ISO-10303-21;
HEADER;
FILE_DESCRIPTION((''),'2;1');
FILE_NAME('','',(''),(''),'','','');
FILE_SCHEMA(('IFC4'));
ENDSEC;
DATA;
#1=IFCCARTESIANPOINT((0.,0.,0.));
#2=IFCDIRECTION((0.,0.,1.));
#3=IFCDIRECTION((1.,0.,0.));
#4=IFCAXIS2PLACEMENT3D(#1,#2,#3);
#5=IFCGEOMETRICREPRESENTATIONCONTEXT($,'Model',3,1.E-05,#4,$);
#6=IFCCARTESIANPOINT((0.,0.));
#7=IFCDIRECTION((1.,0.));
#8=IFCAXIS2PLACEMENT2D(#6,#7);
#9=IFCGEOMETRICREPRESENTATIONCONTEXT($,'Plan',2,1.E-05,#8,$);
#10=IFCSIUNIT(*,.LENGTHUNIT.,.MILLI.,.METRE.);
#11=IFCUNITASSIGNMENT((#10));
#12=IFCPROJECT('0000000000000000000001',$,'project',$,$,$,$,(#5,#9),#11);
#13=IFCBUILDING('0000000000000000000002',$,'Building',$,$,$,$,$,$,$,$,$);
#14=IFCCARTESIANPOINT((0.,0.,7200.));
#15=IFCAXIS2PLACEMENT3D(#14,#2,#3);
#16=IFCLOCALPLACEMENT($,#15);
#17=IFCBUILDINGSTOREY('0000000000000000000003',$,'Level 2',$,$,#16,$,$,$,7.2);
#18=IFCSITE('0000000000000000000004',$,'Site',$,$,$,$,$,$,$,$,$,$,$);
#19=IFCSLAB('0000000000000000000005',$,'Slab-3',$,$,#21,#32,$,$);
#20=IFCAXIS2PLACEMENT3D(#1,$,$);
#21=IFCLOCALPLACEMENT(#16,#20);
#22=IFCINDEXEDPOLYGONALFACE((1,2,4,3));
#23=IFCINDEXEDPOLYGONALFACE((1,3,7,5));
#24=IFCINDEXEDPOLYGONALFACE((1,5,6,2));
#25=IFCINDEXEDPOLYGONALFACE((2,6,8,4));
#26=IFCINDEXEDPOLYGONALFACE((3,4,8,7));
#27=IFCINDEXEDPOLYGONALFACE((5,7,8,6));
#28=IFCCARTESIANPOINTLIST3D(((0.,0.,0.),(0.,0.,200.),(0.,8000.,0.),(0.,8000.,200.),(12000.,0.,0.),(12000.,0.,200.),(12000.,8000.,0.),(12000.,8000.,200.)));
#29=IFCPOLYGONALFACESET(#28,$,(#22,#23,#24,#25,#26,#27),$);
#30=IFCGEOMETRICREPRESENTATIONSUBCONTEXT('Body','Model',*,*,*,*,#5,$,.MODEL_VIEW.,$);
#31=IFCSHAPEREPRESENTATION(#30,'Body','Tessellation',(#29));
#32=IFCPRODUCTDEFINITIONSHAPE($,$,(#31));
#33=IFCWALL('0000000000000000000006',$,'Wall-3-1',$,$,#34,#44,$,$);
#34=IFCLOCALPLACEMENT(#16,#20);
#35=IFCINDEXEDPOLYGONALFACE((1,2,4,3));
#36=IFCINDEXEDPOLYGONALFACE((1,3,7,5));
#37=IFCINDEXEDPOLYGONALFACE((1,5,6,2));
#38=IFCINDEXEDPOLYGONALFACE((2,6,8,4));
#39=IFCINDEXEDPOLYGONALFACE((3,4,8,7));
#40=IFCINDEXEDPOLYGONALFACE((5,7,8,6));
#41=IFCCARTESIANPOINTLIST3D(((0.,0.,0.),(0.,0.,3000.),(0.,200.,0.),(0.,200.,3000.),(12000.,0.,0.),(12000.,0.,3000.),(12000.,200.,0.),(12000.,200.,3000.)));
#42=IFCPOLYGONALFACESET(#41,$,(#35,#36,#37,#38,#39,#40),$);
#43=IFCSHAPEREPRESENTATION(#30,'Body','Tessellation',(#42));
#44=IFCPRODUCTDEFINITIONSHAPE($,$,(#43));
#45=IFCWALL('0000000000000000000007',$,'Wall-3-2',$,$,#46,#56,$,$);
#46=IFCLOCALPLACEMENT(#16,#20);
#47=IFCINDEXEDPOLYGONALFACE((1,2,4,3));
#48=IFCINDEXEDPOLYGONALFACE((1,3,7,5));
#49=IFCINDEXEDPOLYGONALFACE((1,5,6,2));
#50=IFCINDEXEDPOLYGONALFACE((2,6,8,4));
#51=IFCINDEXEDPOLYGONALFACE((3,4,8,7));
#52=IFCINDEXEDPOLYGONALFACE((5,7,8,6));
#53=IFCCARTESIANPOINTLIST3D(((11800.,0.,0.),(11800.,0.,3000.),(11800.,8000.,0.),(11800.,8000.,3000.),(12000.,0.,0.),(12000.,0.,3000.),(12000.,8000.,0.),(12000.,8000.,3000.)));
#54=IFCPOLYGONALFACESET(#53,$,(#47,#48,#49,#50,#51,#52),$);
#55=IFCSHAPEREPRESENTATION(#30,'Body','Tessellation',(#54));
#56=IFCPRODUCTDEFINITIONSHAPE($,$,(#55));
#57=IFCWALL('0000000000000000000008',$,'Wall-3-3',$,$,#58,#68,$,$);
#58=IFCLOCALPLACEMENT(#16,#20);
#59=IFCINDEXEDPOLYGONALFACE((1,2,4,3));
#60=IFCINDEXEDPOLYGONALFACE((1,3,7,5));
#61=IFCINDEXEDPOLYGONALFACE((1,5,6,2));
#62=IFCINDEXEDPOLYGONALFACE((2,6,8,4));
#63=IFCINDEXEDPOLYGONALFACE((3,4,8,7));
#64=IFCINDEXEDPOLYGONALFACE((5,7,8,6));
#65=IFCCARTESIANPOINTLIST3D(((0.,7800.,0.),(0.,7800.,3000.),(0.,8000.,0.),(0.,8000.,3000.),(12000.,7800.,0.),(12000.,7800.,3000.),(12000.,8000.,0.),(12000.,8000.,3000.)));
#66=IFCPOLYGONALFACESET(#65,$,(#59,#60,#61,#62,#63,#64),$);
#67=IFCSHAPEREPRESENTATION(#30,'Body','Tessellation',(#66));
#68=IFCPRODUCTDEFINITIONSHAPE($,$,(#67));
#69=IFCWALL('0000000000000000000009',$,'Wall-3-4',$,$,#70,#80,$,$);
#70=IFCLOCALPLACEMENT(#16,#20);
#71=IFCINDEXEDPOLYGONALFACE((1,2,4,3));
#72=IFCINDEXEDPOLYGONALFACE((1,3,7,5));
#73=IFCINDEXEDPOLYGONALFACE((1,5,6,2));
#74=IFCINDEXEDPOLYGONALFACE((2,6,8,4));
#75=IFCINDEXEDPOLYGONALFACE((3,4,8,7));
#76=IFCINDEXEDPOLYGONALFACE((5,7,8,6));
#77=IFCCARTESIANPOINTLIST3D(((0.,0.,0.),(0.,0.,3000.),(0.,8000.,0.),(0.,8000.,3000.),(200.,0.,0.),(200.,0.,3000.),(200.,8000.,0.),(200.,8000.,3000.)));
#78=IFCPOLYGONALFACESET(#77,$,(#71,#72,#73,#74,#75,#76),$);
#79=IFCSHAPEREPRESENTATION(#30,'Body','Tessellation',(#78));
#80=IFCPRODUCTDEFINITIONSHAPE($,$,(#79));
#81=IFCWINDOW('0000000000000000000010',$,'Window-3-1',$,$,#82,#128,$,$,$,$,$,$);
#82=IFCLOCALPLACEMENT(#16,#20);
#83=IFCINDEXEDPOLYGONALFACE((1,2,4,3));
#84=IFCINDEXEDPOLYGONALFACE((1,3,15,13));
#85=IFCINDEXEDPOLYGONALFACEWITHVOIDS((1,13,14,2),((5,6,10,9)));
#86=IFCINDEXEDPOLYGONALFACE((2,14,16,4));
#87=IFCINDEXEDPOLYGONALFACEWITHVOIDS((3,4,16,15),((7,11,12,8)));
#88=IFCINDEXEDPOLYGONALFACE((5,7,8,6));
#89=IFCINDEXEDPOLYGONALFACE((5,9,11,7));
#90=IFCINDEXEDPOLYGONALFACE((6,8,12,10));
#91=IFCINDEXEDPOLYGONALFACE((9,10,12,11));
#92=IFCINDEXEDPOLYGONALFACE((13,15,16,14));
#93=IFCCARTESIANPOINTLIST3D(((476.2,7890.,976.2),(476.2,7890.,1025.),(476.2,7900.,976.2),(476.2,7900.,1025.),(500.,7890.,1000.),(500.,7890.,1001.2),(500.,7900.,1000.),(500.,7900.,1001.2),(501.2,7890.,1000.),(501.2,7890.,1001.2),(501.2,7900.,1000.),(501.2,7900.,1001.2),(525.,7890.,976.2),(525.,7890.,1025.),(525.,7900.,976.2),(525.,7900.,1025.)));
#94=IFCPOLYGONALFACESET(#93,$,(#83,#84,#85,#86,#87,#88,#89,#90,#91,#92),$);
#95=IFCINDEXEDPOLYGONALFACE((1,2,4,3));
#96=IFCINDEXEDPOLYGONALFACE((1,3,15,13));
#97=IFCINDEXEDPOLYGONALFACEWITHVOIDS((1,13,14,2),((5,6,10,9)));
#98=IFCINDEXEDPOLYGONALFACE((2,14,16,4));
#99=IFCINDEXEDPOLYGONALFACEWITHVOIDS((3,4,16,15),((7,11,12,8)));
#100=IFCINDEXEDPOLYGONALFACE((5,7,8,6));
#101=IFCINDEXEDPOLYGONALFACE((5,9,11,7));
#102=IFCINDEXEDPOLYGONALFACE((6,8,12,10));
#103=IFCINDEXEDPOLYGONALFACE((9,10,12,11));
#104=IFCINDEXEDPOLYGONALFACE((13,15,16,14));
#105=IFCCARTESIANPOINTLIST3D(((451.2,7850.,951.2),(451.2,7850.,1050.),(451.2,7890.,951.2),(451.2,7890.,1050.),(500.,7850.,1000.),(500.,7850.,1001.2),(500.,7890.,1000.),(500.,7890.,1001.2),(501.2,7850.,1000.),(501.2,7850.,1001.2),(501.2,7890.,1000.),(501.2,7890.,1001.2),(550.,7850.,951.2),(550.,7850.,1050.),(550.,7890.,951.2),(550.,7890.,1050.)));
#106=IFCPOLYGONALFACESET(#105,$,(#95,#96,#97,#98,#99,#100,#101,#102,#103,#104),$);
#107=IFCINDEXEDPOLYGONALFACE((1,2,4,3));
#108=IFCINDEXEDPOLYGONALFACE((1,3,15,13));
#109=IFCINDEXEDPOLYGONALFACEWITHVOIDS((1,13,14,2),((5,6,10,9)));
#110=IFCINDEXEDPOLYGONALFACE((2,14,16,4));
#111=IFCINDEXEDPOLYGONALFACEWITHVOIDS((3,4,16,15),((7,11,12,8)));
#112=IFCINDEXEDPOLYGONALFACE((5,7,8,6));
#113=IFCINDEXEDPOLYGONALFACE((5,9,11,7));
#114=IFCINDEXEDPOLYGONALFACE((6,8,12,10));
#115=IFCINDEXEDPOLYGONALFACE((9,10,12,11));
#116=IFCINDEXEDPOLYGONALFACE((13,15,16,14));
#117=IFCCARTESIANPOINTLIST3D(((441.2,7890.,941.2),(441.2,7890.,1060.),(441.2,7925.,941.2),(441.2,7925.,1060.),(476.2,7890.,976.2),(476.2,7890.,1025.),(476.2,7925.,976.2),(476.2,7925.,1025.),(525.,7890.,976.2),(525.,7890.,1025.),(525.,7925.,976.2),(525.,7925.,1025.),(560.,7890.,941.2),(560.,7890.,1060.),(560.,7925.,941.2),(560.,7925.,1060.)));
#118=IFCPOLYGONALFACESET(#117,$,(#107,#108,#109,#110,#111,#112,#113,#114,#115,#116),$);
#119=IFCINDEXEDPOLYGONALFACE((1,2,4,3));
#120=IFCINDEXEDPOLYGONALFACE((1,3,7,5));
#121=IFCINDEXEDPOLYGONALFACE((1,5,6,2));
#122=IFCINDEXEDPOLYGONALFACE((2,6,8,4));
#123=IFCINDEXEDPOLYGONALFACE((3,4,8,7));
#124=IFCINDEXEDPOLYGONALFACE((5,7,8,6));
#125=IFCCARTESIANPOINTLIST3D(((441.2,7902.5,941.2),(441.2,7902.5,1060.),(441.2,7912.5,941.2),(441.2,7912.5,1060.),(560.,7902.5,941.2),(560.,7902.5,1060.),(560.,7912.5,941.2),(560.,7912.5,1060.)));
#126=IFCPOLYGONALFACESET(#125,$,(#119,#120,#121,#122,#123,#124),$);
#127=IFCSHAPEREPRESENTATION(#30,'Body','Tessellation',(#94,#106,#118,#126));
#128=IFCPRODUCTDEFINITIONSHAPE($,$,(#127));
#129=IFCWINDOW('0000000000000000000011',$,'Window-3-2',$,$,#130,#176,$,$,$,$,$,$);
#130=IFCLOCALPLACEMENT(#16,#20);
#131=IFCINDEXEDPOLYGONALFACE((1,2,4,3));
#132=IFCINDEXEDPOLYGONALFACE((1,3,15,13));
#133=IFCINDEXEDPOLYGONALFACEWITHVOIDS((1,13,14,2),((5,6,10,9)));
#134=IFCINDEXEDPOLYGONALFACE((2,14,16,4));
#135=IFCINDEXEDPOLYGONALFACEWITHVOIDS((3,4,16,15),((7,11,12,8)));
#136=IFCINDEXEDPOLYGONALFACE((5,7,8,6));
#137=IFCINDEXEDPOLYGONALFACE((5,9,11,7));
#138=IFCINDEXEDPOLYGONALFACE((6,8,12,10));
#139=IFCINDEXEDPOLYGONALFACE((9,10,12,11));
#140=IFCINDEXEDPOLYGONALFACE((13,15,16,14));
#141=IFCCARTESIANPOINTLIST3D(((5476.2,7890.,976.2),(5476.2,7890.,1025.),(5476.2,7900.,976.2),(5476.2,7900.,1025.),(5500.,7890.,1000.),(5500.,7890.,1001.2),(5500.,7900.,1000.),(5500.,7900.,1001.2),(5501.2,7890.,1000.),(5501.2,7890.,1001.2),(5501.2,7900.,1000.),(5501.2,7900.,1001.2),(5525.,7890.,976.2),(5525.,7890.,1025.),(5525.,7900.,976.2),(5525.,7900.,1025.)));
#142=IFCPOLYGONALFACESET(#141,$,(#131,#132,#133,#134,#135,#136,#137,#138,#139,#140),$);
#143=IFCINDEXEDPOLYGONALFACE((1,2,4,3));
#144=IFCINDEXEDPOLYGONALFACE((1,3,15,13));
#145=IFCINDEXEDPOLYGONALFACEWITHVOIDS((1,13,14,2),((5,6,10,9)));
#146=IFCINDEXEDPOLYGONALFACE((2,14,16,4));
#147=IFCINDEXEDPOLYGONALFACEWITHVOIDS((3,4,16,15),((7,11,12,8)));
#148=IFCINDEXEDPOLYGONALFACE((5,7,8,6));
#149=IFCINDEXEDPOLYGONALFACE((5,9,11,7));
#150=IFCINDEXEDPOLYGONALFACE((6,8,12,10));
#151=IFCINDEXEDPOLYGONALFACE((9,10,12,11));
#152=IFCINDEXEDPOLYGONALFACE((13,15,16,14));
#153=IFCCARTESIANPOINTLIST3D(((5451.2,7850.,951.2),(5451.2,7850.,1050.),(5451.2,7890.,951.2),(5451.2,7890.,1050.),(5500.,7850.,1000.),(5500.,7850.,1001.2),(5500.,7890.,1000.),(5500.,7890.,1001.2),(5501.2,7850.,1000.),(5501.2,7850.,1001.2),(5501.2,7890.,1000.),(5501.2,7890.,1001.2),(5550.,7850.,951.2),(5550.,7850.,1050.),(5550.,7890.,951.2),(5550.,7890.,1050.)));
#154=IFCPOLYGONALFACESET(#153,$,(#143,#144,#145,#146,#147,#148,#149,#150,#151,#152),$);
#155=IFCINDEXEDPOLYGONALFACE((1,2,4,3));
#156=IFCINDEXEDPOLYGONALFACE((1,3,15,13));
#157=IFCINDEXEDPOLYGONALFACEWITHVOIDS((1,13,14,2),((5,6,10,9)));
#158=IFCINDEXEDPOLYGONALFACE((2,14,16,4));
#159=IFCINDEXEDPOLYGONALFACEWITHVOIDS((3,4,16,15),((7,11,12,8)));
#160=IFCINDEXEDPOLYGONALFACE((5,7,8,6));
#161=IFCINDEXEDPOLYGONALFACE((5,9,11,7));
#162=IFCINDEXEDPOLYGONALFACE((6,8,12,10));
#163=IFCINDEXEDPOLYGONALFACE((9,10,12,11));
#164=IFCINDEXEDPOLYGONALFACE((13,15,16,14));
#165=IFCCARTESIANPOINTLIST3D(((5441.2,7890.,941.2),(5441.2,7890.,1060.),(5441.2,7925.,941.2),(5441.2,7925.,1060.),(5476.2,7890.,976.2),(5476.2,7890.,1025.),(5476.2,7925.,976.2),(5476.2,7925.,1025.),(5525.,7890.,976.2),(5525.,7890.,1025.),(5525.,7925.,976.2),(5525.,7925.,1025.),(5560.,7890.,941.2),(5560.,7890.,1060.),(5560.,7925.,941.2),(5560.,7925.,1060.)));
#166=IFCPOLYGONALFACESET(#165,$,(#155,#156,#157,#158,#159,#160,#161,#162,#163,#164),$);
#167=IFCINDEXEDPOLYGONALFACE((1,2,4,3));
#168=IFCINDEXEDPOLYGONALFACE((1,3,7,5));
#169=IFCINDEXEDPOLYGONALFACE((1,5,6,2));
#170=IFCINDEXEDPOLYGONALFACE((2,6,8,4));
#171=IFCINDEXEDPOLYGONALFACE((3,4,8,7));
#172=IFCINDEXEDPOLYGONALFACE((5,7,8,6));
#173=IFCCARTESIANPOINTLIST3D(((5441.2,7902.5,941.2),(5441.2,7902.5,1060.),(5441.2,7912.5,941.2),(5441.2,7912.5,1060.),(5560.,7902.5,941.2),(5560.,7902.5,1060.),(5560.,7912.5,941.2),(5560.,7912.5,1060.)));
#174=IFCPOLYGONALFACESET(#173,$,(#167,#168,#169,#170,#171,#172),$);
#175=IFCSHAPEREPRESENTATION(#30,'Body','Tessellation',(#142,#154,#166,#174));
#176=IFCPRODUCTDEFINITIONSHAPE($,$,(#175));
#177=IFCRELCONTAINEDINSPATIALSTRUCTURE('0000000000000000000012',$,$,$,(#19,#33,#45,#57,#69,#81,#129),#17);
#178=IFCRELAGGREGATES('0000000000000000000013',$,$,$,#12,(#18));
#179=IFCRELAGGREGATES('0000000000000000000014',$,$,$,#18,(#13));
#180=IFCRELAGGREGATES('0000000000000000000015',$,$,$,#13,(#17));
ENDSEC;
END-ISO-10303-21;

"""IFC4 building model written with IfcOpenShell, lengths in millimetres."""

from ifc_helpers import new_model, si_unit, frame, origin_with_axes, origin_2d_with_axis, place, context, subcontext, project, spatial, line, indexed_curve, outline, extrude, element, save


model = new_model("IFC4")

# Units and contexts
model_context = context("Model", 3, precision=1e-05, world=origin_with_axes())
plan_context = context("Plan", 2, precision=1e-05, world=origin_2d_with_axis())
body_context = subcontext(model_context, "Body", "Model", "MODEL_VIEW")
ifc_project = project(units=[si_unit("LENGTHUNIT", "METRE", prefix="MILLI")], contexts=[model_context, plan_context])

# Site, building, storey
site = spatial("IfcSite", under=ifc_project, Name="Site")
building = spatial("IfcBuilding", under=site, Name="Building")
storey_placement = place(None, frame((0.0, 0.0, 7200.0), z_axis=(0.0, 0.0, 1.0), x_axis=(1.0, 0.0, 0.0)))
storey = spatial("IfcBuildingStorey", under=building, at=storey_placement, Name="Level 2", Elevation=7.2)

# Slab
slab_placement = place(storey_placement, origin_with_axes())
element("IfcSlab", 1, at=slab_placement, inside=storey, Name="Slab-3", context=body_context, shape_type="SweptSolid", body=[
    extrude(outline(indexed_curve([(0.0, 0.0), (12000.0, 0.0), (12000.0, 8000.0), (0.0, 8000.0), (0.0, 0.0)])), None, (0.0, 0.0, 1.0), 200.0),
])

# Walls
wall_1_placement = place(storey_placement, origin_with_axes())
element("IfcWall", 2, at=wall_1_placement, inside=storey, Name="Wall-3-1", context=body_context, shape_type="SweptSolid", body=[
    extrude(outline(indexed_curve([(0.0, 0.0), (0.0, 200.0), (12000.0, 200.0), (12000.0, 0.0), (0.0, 0.0)], self_intersect=False)), origin_with_axes(), (0.0, 0.0, 1.0), 3000.0),
])
wall_2_placement = place(storey_placement, frame((12000.0, 0.0, 0.0), z_axis=(0.0, 0.0, 1.0), x_axis=(0.0, 1.0, 0.0)))
element("IfcWall", 3, at=wall_2_placement, inside=storey, Name="Wall-3-2", context=body_context, shape_type="SweptSolid", body=[
    extrude(outline(indexed_curve([(0.0, 0.0), (0.0, 200.0), (8000.0, 200.0), (8000.0, 0.0), (0.0, 0.0)], self_intersect=False)), origin_with_axes(), (0.0, 0.0, 1.0), 3000.0),
])
wall_3_placement = place(storey_placement, frame((12000.0, 8000.0, 0.0), z_axis=(0.0, 0.0, 1.0), x_axis=(-1.0, 0.0, 0.0)))
element("IfcWall", 4, at=wall_3_placement, inside=storey, Name="Wall-3-3", context=body_context, shape_type="SweptSolid", body=[
    extrude(outline(indexed_curve([(0.0, 0.0), (0.0, 200.0), (12000.0, 200.0), (12000.0, 0.0), (0.0, 0.0)], self_intersect=False)), origin_with_axes(), (0.0, 0.0, 1.0), 3000.0),
])
wall_4_placement = place(storey_placement, frame((0.0, 8000.0, 0.0), z_axis=(0.0, 0.0, 1.0), x_axis=(0.0, -1.0, 0.0)))
element("IfcWall", 5, at=wall_4_placement, inside=storey, Name="Wall-3-4", context=body_context, shape_type="SweptSolid", body=[
    extrude(outline(indexed_curve([(0.0, 0.0), (0.0, 200.0), (8000.0, 200.0), (8000.0, 0.0), (0.0, 0.0)], self_intersect=False)), origin_with_axes(), (0.0, 0.0, 1.0), 3000.0),
])

# Windows
for number, where, z_axis, x_axis, name in (
    (6, (500.0, 7800.0, 1000.0), (0.0, 0.0, 1.0), (1.0, 0.0, 0.0), "Window-3-1"),
    (7, (5500.0, 7800.0, 1000.0), (0.0, 0.0, 1.0), (1.0, 0.0, 0.0), "Window-3-2"),
):
    element("IfcWindow", number, at=place(storey_placement, frame(where, z_axis=z_axis, x_axis=x_axis)), inside=storey, Name=name, context=body_context, shape_type="SweptSolid", body=[
        extrude(outline(indexed_curve([(0.0, 0.0), (1.2, 0.0), (1.2, 1.2), (0.0, 1.2)], segments=[line(1, 2, 3, 4, 1)]), holes=[indexed_curve([(25.0, 25.0), (-23.8, 25.0), (-23.8, -23.8), (25.0, -23.8)], segments=[line(1, 2, 3, 4, 1)])]), frame((0.0, 90.0, 0.0), z_axis=(0.0, -1.0, 0.0), x_axis=(1.0, 0.0, 0.0)), (0.0, 0.0, -1.0), 10.0),
        extrude(outline(indexed_curve([(0.0, 0.0), (1.2, 0.0), (1.2, 1.2), (0.0, 1.2)], segments=[line(1, 2, 3, 4, 1)]), holes=[indexed_curve([(50.0, 50.0), (-48.8, 50.0), (-48.8, -48.8), (50.0, -48.8)], segments=[line(1, 2, 3, 4, 1)])]), frame((0.0, 50.0, 0.0), z_axis=(0.0, -1.0, 0.0), x_axis=(1.0, 0.0, 0.0)), (0.0, 0.0, -1.0), 40.0),
        extrude(outline(indexed_curve([(0.0, 0.0), (-48.8, 0.0), (-48.8, -48.8), (0.0, -48.8)], segments=[line(1, 2, 3, 4, 1)]), holes=[indexed_curve([(35.0, 35.0), (-83.8, 35.0), (-83.8, -83.8), (35.0, -83.8)], segments=[line(1, 2, 3, 4, 1)])]), frame((25.0, 90.0, 25.0), z_axis=(0.0, -1.0, 0.0), x_axis=(1.0, 0.0, 0.0)), (0.0, 0.0, -1.0), 35.0),
        extrude(outline(indexed_curve([(35.0, 35.0), (-83.8, 35.0), (-83.8, -83.8), (35.0, -83.8)], segments=[line(1, 2, 3, 4, 1)])), frame((25.0, 102.5, 25.0), z_axis=(0.0, -1.0, 0.0), x_axis=(1.0, 0.0, 0.0)), (0.0, 0.0, -1.0), 10.0),
    ])

save(model, "model.ifc")
